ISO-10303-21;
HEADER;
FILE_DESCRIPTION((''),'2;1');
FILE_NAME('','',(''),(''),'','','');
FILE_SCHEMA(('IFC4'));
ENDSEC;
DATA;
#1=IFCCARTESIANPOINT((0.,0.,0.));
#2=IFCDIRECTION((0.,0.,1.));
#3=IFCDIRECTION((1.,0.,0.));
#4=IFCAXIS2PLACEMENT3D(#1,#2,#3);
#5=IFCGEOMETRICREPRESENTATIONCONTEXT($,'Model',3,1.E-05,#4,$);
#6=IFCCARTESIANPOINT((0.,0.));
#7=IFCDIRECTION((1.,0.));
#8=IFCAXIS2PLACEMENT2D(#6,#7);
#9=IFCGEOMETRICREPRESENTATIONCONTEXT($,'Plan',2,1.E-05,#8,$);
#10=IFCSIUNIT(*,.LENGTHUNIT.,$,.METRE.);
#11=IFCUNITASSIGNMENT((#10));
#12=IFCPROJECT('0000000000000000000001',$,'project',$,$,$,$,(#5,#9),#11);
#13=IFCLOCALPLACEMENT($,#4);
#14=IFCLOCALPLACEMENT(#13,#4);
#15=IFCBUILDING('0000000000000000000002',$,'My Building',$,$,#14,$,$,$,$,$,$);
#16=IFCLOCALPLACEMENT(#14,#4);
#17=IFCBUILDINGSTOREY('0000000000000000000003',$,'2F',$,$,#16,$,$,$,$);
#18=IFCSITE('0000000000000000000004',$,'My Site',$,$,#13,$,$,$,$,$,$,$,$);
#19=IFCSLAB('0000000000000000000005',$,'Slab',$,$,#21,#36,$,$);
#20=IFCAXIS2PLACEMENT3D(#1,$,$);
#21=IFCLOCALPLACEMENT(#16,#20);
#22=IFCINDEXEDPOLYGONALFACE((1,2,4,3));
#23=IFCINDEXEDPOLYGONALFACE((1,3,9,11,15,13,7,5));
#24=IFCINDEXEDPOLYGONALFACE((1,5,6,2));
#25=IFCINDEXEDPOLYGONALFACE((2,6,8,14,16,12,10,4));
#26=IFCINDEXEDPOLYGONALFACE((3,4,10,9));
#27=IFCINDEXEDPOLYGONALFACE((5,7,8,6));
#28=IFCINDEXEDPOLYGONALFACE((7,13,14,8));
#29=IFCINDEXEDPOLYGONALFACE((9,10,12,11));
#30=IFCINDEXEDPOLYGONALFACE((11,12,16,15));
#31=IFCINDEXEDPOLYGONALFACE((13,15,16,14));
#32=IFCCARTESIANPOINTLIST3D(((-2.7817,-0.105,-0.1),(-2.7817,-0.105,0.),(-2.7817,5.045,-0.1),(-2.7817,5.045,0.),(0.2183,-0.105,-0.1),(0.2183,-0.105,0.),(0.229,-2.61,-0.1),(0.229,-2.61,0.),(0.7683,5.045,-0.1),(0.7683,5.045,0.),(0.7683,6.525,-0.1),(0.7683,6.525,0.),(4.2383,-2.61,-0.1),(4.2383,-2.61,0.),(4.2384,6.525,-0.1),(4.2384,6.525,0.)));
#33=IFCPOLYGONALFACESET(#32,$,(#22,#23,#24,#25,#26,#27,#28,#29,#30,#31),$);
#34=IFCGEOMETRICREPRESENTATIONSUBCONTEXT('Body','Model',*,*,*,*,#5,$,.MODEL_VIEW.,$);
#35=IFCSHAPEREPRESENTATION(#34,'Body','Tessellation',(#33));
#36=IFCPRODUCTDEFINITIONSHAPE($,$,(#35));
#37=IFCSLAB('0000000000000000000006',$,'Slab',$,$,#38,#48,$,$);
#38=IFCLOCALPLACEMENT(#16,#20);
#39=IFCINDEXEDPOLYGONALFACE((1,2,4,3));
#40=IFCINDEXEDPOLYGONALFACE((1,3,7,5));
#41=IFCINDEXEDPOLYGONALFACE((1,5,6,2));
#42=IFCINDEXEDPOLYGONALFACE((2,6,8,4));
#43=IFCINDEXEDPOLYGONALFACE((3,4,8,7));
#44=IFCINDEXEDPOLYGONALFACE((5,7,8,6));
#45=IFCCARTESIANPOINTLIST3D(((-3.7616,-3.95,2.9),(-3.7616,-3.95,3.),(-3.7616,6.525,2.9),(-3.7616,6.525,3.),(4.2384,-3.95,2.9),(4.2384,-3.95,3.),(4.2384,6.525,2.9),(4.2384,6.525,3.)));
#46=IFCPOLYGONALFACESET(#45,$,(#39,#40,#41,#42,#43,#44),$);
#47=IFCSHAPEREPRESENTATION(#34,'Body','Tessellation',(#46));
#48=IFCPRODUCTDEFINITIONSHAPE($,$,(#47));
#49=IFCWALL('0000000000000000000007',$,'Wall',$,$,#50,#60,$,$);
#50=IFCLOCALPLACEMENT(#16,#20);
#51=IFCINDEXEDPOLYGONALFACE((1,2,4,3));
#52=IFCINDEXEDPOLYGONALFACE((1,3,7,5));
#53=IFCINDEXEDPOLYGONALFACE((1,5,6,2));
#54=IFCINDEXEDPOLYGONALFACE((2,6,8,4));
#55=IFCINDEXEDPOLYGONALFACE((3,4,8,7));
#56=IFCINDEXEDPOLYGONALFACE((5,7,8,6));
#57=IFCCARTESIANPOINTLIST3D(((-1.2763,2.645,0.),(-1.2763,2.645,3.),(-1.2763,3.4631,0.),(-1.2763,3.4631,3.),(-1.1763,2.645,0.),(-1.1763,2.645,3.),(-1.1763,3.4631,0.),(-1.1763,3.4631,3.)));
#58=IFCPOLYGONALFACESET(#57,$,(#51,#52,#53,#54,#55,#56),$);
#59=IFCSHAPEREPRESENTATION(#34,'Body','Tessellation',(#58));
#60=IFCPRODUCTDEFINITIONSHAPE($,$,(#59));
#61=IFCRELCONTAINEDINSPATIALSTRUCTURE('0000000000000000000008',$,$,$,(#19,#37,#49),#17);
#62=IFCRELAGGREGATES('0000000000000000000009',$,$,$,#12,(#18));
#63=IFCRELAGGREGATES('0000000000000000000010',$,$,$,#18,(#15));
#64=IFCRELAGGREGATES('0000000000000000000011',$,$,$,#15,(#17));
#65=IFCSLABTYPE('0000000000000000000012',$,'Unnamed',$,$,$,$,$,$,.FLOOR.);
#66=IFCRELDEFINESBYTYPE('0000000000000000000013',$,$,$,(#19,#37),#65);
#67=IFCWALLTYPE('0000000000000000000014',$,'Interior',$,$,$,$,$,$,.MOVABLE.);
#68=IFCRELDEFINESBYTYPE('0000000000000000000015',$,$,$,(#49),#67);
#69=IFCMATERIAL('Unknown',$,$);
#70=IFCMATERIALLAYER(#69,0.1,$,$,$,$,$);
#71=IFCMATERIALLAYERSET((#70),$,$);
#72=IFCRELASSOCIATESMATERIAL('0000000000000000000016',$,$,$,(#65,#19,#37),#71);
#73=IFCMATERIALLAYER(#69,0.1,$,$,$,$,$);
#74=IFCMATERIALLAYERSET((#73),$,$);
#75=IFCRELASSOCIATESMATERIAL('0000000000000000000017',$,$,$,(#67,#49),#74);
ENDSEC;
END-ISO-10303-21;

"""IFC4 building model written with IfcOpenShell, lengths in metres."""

from ifc_helpers import new_model, si_unit, frame, origin_with_axes, origin_2d_with_axis, place, context, subcontext, project, spatial, line, indexed_curve, outline, extrude, material, layer, layer_set, layer_usage, type_object, element, save


model = new_model("IFC4")

# Units and contexts
model_context = context("Model", 3, precision=1e-05, world=origin_with_axes())
plan_context = context("Plan", 2, precision=1e-05, world=origin_2d_with_axis())
body_context_1 = subcontext(model_context, "Body", "Model", "MODEL_VIEW")
ifc_project = project(units=[si_unit("LENGTHUNIT", "METRE")], contexts=[model_context, plan_context])

# Site, building, storey
site_placement = place(None, origin_with_axes())
site = spatial("IfcSite", under=ifc_project, at=site_placement, Name="My Site")
building_placement = place(site_placement, origin_with_axes())
building = spatial("IfcBuilding", under=site, at=building_placement, Name="My Building")
storey_placement = place(building_placement, origin_with_axes())
storey = spatial("IfcBuildingStorey", under=building, at=storey_placement, Name="2F")

# Slabs
ifc_material = material(Name="Unknown")
ifc_layer_1 = layer(ifc_material, 0.1)
ifc_layer_set_1 = layer_set([ifc_layer_1])
ifc_layer_usage_1 = layer_usage(ifc_layer_set_1, "AXIS3", "POSITIVE", -0.1)
slab_type = type_object("IfcSlabType", Name="Unnamed", PredefinedType="FLOOR", material=ifc_layer_set_1)
slab_1_placement = place(storey_placement, frame((4.2383, -2.61, 0.0), z_axis=(0.0, 0.0, 1.0), x_axis=(1.0, 0.0, 0.0)))
element("IfcSlab", 1, at=slab_1_placement, inside=storey, type_object=slab_type, material=ifc_layer_usage_1, Name="Slab", context=body_context_1, shape_type="SweptSolid", body=[
    extrude(outline(indexed_curve([(0.0, 0.0), (0.0, 9.135), (-3.47, 9.135), (-3.47, 7.655), (-7.02, 7.655), (-7.02, 2.505), (-4.02, 2.505), (-4.0094, 0.0), (0.0, 0.0)])), frame((0.0, 0.0, -0.1), z_axis=(0.0, 0.0, 1.0), x_axis=(1.0, 0.0, 0.0)), (0.0, 0.0, 1.0), 0.1),
])
ifc_layer_usage_2 = layer_usage(ifc_layer_set_1, "AXIS3", "POSITIVE", -0.1)
slab_2_placement = place(storey_placement, frame((4.2384, 6.525, 3.0), z_axis=(0.0, 0.0, 1.0), x_axis=(1.0, 0.0, 0.0)))
element("IfcSlab", 2, at=slab_2_placement, inside=storey, type_object=slab_type, material=ifc_layer_usage_2, Name="Slab", context=body_context_1, shape_type="SweptSolid", body=[
    extrude(outline(indexed_curve([(0.0, 0.0), (-8.0, 0.0), (-8.0, -10.475), (0.0, -10.475), (0.0, 0.0)])), frame((0.0, 0.0, -0.1), z_axis=(0.0, 0.0, 1.0), x_axis=(1.0, 0.0, 0.0)), (0.0, 0.0, 1.0), 0.1),
])

# Wall
ifc_layer_2 = layer(ifc_material, 0.1)
ifc_layer_set_2 = layer_set([ifc_layer_2])
ifc_layer_usage_3 = layer_usage(ifc_layer_set_2, "AXIS2", "POSITIVE", 0.0)
wall_type = type_object("IfcWallType", Name="Interior", PredefinedType="MOVABLE", material=ifc_layer_set_2)
wall_1_placement = place(storey_placement, frame((-1.2763, 3.4631, 0.0), z_axis=(0.0, 0.0, 1.0), x_axis=(0.0, -1.0, 0.0)))
element("IfcWall", 3, at=wall_1_placement, inside=storey, type_object=wall_type, material=ifc_layer_usage_3, Name="Wall", context=body_context_1, shape_type="SweptSolid", body=[
    extrude(outline(indexed_curve([(0.0, 0.0), (0.0, 0.1), (0.8182, 0.1), (0.8182, 0.0)], segments=[line(1, 2, 3, 4, 1)])), origin_with_axes(), (0.0, 0.0, 1.0), 3.0),
])

save(model, "model.ifc")
